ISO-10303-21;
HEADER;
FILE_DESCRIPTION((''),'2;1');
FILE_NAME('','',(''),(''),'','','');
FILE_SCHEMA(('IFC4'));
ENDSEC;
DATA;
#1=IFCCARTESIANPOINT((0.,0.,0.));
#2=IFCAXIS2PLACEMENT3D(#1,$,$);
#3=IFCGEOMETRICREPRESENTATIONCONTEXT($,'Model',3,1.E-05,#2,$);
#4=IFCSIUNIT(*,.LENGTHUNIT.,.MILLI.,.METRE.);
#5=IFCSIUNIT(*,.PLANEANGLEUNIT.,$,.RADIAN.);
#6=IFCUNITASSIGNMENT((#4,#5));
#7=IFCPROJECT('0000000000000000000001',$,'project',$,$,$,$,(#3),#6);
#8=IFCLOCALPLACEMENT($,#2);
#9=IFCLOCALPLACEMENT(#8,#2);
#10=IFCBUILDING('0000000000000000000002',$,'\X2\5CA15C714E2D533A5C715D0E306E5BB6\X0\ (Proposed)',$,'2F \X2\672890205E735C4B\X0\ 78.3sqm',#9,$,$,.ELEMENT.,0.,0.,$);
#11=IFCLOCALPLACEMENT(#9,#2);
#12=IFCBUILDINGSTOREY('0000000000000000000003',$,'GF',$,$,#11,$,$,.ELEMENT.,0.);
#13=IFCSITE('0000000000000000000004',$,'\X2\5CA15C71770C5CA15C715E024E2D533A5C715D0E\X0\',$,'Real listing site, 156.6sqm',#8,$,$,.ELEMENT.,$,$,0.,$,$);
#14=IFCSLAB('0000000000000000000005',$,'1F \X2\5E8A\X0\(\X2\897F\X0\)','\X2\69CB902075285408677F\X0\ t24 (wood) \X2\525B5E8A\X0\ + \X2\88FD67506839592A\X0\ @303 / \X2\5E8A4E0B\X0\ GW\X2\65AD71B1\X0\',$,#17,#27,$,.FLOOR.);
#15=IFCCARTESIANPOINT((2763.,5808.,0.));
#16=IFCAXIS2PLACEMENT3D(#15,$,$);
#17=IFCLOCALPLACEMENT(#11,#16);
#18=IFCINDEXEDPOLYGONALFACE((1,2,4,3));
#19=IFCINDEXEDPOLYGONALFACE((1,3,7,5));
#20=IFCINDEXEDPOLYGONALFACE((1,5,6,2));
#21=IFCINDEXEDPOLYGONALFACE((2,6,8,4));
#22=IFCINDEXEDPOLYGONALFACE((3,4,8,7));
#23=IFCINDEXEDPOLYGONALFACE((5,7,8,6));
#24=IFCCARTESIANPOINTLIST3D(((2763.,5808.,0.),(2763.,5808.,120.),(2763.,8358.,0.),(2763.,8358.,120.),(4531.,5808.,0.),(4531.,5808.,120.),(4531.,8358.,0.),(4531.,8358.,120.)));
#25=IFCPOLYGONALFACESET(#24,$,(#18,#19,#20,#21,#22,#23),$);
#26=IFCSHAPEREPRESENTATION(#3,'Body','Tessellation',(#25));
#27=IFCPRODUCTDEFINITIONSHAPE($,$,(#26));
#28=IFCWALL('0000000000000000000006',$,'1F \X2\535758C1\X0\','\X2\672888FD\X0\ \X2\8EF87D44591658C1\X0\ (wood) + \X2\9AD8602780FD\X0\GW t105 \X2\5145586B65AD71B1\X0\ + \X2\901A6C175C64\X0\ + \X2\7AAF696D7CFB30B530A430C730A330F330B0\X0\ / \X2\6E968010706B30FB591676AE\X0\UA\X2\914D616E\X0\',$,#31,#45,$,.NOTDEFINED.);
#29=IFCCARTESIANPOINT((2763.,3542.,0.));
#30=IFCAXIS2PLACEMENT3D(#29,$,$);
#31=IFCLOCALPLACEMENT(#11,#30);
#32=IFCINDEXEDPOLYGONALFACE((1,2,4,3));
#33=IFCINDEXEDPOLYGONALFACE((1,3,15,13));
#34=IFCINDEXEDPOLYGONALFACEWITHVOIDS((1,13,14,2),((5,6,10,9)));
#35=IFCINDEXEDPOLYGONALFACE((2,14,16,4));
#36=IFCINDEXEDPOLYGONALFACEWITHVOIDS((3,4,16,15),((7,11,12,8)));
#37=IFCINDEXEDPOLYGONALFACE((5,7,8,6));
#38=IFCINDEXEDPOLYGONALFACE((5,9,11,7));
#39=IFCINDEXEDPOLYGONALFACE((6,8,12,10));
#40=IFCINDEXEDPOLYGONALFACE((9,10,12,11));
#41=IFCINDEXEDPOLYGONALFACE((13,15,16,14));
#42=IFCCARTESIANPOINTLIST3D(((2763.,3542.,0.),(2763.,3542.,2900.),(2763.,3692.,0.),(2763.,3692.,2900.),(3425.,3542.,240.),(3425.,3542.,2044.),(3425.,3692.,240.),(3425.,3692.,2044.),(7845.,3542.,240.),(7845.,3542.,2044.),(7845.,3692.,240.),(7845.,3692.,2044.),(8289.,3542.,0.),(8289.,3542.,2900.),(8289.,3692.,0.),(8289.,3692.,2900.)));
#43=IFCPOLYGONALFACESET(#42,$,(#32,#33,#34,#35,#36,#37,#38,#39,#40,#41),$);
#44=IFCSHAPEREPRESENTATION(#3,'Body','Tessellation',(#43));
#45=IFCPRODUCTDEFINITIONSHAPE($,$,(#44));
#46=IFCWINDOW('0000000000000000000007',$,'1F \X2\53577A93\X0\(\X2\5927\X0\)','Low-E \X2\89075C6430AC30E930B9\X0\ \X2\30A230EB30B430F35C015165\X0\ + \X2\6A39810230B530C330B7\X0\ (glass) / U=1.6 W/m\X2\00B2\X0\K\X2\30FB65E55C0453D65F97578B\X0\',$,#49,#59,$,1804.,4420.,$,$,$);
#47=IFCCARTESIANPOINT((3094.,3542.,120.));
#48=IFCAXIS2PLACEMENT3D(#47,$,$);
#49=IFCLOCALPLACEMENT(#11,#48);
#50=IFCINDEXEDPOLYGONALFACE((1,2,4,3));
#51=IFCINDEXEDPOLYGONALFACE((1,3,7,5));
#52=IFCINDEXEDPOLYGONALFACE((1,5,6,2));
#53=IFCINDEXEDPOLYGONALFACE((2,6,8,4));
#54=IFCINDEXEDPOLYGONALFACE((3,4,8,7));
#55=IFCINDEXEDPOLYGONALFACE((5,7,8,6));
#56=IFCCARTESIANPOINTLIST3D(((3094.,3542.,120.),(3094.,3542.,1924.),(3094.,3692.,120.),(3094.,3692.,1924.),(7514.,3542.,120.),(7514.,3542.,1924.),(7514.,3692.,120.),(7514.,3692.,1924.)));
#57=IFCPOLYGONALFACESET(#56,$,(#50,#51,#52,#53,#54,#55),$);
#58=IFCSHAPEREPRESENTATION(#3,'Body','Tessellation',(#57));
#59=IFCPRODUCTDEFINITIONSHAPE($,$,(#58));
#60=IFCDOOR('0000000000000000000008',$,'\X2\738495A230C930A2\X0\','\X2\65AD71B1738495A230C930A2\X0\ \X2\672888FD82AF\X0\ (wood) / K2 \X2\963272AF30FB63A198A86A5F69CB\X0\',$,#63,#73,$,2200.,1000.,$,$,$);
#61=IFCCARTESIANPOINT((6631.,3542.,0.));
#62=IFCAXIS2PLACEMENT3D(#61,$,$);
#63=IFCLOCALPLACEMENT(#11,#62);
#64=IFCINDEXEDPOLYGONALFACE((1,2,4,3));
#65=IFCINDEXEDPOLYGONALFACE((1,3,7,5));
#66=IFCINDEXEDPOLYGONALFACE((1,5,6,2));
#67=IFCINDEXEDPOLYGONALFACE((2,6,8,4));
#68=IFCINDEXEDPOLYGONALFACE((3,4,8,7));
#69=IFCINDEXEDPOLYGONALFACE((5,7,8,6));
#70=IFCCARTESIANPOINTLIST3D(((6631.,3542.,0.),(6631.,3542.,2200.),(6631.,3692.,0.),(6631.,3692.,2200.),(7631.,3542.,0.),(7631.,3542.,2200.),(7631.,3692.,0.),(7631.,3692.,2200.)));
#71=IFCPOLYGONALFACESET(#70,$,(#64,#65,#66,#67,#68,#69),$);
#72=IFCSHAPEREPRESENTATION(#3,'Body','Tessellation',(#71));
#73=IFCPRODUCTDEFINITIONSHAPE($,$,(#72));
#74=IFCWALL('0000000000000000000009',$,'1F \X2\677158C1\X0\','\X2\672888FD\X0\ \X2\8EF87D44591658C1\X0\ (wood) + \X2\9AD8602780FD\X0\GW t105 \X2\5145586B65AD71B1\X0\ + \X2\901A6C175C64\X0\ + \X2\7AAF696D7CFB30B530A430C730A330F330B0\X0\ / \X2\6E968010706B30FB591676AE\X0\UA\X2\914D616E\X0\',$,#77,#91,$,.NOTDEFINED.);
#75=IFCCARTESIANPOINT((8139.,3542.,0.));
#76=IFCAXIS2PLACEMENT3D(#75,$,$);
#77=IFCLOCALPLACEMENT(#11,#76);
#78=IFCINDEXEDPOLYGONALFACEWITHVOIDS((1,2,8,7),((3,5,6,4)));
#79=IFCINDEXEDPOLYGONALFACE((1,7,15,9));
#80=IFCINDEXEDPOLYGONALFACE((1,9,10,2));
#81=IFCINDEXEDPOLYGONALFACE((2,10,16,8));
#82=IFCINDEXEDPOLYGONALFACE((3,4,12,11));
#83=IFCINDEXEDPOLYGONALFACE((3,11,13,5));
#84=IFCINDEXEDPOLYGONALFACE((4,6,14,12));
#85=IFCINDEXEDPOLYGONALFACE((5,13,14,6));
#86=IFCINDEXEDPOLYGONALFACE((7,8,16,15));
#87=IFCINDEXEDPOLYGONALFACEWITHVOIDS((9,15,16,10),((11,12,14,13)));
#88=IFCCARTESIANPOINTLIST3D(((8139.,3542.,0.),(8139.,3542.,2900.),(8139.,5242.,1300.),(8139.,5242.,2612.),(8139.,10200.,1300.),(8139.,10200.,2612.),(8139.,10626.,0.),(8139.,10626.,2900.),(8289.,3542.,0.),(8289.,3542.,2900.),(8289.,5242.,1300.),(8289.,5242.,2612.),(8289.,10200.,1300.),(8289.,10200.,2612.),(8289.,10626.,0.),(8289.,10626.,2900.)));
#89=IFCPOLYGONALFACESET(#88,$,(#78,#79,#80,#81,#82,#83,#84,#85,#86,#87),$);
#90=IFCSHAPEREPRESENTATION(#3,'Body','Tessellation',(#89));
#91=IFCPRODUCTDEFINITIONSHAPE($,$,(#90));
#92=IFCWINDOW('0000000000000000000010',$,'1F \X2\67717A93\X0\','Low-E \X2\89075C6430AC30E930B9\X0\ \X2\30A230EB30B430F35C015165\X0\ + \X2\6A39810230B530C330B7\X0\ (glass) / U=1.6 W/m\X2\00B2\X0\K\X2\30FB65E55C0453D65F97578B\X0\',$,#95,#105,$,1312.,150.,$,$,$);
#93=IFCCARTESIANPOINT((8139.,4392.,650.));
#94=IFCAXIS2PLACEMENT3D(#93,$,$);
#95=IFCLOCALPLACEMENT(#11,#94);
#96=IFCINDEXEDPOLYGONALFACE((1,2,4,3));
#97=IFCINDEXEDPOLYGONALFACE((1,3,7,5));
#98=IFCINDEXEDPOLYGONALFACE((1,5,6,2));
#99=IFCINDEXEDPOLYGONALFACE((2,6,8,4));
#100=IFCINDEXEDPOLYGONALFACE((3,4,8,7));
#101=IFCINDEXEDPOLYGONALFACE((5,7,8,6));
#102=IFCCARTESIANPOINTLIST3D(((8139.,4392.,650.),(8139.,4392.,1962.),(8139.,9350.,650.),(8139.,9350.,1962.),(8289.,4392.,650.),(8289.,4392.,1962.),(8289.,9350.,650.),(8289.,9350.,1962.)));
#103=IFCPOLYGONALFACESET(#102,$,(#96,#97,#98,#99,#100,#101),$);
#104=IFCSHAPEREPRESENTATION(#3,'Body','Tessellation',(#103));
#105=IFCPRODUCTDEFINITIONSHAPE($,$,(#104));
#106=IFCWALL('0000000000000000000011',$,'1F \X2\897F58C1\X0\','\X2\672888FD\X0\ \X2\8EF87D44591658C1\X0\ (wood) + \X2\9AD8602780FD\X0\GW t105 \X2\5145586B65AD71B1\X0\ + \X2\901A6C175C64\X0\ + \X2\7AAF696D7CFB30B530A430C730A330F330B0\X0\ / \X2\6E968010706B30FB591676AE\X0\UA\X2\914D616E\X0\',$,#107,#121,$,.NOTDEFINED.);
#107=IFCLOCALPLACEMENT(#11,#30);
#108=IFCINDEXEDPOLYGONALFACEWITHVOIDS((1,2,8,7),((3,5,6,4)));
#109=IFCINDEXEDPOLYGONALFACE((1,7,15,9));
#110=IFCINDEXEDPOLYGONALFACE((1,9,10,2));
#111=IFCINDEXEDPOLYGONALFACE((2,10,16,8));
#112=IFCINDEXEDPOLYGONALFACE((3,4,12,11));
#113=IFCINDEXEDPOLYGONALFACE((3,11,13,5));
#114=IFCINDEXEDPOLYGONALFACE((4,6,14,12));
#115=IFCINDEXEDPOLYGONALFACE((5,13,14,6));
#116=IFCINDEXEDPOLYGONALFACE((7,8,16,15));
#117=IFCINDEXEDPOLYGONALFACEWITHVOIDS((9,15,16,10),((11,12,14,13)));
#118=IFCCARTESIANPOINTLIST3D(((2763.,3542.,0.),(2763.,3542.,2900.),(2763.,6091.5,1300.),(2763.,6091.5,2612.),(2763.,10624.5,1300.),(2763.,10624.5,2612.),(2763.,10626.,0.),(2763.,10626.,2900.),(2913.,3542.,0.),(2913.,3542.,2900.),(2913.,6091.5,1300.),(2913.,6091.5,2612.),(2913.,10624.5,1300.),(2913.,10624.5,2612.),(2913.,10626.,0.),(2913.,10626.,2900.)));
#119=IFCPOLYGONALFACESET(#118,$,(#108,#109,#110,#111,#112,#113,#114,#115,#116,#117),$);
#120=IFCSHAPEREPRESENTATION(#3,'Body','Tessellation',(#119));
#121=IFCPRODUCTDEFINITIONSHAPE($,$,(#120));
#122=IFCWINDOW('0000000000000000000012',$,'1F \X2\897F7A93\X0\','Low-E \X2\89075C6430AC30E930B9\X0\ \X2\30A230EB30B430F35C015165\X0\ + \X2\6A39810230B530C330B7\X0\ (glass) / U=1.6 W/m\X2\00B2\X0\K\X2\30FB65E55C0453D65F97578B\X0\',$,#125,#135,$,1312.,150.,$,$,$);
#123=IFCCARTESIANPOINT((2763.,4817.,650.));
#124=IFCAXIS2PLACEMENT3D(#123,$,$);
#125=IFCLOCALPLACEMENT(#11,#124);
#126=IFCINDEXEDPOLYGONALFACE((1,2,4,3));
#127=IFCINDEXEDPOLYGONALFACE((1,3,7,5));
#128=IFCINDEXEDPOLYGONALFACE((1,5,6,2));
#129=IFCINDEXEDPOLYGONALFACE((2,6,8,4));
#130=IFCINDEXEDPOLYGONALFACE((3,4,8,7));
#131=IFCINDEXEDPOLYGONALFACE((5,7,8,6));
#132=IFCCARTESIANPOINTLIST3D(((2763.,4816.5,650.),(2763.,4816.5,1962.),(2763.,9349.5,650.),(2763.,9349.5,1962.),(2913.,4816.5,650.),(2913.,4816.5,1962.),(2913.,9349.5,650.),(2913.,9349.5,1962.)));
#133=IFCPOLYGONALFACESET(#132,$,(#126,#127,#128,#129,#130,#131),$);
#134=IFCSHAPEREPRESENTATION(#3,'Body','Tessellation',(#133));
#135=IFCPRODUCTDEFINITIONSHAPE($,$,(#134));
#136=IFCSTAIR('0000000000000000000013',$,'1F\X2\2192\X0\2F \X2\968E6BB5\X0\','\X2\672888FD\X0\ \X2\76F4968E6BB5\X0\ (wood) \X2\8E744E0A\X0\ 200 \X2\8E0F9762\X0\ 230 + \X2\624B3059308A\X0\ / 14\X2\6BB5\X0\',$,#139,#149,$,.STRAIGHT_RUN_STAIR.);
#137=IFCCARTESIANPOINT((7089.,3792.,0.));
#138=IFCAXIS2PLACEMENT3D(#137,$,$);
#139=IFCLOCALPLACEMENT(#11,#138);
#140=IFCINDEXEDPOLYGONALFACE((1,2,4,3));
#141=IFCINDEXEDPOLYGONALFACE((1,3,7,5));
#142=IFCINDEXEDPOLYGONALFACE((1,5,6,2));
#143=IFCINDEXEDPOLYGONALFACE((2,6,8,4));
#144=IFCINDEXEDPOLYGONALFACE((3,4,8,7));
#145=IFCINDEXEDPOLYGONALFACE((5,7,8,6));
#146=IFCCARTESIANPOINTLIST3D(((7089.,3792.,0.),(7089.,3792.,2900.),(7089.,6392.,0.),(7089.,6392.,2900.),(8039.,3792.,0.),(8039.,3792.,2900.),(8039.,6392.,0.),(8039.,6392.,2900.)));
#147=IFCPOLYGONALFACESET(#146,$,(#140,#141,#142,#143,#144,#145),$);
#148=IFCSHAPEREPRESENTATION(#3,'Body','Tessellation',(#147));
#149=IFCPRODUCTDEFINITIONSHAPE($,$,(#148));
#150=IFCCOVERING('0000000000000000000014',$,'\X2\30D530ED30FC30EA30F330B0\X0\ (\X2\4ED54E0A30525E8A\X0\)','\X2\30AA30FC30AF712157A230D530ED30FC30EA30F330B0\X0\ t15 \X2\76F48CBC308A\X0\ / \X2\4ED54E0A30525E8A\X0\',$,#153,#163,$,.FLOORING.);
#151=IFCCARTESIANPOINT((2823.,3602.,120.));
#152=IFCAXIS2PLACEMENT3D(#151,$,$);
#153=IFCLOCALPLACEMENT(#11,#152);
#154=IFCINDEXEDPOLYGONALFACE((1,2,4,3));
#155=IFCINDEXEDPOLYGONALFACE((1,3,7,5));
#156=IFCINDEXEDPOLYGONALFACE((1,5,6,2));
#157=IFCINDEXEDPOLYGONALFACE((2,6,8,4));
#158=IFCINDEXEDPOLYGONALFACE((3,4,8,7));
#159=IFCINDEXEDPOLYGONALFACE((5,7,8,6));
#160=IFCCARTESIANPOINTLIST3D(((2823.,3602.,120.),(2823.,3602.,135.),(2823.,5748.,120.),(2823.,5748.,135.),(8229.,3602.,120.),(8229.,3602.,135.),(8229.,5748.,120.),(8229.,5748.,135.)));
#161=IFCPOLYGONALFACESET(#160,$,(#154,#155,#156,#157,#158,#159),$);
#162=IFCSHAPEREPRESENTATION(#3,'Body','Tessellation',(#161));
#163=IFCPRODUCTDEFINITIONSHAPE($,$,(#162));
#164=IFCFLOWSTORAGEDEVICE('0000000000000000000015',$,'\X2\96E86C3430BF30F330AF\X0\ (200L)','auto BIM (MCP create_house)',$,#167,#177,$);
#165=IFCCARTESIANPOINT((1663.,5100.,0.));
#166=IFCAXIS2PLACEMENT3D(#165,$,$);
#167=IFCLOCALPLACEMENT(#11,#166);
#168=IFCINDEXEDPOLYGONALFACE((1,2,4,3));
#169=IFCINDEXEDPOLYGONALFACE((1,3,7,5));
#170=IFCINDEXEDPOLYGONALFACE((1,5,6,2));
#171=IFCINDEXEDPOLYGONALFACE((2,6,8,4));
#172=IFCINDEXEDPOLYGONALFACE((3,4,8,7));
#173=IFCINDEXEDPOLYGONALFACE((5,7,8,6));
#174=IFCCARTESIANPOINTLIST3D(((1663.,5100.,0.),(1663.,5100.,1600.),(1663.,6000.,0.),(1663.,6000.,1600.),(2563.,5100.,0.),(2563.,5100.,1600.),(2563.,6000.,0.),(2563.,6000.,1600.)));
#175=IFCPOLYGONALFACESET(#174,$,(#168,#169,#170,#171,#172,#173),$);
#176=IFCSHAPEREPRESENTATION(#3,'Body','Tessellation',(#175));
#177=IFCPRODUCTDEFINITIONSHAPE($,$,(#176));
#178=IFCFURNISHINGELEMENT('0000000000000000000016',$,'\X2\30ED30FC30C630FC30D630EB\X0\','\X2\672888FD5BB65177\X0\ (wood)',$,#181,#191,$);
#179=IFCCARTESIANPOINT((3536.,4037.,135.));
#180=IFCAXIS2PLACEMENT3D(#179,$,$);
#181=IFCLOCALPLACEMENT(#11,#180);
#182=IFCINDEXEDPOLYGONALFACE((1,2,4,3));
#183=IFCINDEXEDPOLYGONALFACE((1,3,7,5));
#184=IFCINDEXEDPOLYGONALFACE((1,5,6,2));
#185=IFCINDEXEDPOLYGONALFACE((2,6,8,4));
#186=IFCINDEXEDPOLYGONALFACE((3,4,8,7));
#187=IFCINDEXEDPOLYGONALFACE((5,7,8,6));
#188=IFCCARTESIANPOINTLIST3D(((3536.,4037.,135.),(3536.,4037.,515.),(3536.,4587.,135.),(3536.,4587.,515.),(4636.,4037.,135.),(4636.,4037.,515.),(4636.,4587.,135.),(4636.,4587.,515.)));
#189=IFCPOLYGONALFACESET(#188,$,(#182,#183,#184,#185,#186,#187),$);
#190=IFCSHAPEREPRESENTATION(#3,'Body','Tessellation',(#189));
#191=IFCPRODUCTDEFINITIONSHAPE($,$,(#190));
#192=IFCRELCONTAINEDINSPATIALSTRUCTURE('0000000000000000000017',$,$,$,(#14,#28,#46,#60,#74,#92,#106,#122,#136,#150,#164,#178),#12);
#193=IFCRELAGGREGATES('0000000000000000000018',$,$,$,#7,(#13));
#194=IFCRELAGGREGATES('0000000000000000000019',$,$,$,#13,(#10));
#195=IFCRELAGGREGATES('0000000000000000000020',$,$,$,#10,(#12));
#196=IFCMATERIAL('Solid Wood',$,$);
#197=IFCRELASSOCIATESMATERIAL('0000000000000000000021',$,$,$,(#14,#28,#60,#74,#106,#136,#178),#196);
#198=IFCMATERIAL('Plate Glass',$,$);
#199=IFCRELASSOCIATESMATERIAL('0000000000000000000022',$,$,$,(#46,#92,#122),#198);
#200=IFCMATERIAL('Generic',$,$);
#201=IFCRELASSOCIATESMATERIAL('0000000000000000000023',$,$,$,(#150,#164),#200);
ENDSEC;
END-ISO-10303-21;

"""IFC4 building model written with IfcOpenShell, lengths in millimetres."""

from ifc_helpers import new_model, si_unit, frame, frame_2d, origin, place, context, project, spatial, rectangle, extrude, material, element, fill, save


model = new_model("IFC4")

# Units and contexts
model_context = context("Model", 3, precision=1e-05, world=origin())
ifc_project = project(units=[si_unit("LENGTHUNIT", "METRE", prefix="MILLI"), si_unit("PLANEANGLEUNIT", "RADIAN")], contexts=[model_context])

# Site, building, storey
site_placement = place(None, origin())
site = spatial("IfcSite", under=ifc_project, at=site_placement, Name="岡山県岡山市中区山崎", ObjectType="Real listing site, 156.6sqm", CompositionType="ELEMENT", RefElevation=0.0)
building_placement = place(site_placement, origin())
building = spatial("IfcBuilding", under=site, at=building_placement, Name="岡山中区山崎の家 (Proposed)", ObjectType="2F 木造平屋 78.3sqm", CompositionType="ELEMENT", ElevationOfRefHeight=0.0, ElevationOfTerrain=0.0)
storey_placement = place(building_placement, origin())
storey = spatial("IfcBuildingStorey", under=building, at=storey_placement, Name="GF", CompositionType="ELEMENT", Elevation=0.0)

# Slab
ifc_material_1 = material(Name="Solid Wood")
slab_1_placement = place(storey_placement, frame((2763.0, 5808.0, 0.0)))
element("IfcSlab", 1, at=slab_1_placement, inside=storey, material=ifc_material_1, Name="1F 床(西)", Description="構造用合板 t24 (wood) 剛床 + 製材根太 @303 / 床下 GW断熱", PredefinedType="FLOOR", context=model_context, shape_type="SweptSolid", body=[
    extrude(rectangle(XDim=1768.0, YDim=2550.0, at=frame_2d((884.0, 1275.0))), frame((2763.0, 5808.0, 0.0)), (0.0, 0.0, 1.0), 120.0),
])

# Wall, openings, window, door
wall_1_placement = place(storey_placement, frame((2763.0, 3542.0, 0.0)))
wall_1 = element("IfcWall", 2, at=wall_1_placement, inside=storey, material=ifc_material_1, Name="1F 南壁", Description="木製 軸組外壁 (wood) + 高性能GW t105 充填断熱 + 通気層 + 窯業系サイディング / 準耐火・外皮UA配慮", PredefinedType="NOTDEFINED", context=model_context, shape_type="SweptSolid", body=[
    extrude(rectangle(XDim=5526.0, YDim=150.0, at=frame_2d((2763.0, 75.0))), frame((2763.0, 3542.0, 0.0)), (0.0, 0.0, 1.0), 2900.0),
])
opening_1_placement = place(storey_placement, frame((3094.0, 3542.0, 120.0)))
opening_1 = element("IfcOpeningElement", 3, at=opening_1_placement, cuts=wall_1, PredefinedType="NOTDEFINED", context=model_context, shape_type="SweptSolid", body=[
    extrude(rectangle(XDim=4420.0, YDim=150.0, at=frame_2d((2210.0, 75.0))), frame((3094.0, 3542.0, 120.0)), (0.0, 0.0, 1.0), 1804.0),
])
opening_2_placement = place(storey_placement, frame((6631.0, 3542.0, 0.0)))
opening_2 = element("IfcOpeningElement", 4, at=opening_2_placement, cuts=wall_1, PredefinedType="NOTDEFINED", context=model_context, shape_type="SweptSolid", body=[
    extrude(rectangle(XDim=1000.0, YDim=150.0, at=frame_2d((500.0, 75.0))), frame((6631.0, 3542.0, 0.0)), (0.0, 0.0, 1.0), 2200.0),
])
ifc_material_2 = material(Name="Plate Glass")
window_1_placement = place(storey_placement, frame((3094.0, 3542.0, 120.0)))
window_1 = element("IfcWindow", 5, at=window_1_placement, inside=storey, material=ifc_material_2, Name="1F 南窓(大)", Description="Low-E 複層ガラス アルゴン封入 + 樹脂サッシ (glass) / U=1.6 W/m²K・日射取得型", OverallHeight=1804.0, OverallWidth=4420.0, context=model_context, shape_type="SweptSolid", body=[
    extrude(rectangle(XDim=4420.0, YDim=150.0, at=frame_2d((2210.0, 75.0))), frame((3094.0, 3542.0, 120.0)), (0.0, 0.0, 1.0), 1804.0),
])
fill(opening_1, window_1)
door_placement = place(storey_placement, frame((6631.0, 3542.0, 0.0)))
door = element("IfcDoor", 6, at=door_placement, inside=storey, material=ifc_material_1, Name="玄関ドア", Description="断熱玄関ドア 木製芯 (wood) / K2 防犯・採風機構", OverallHeight=2200.0, OverallWidth=1000.0, context=model_context, shape_type="SweptSolid", body=[
    extrude(rectangle(XDim=1000.0, YDim=150.0, at=frame_2d((500.0, 75.0))), frame((6631.0, 3542.0, 0.0)), (0.0, 0.0, 1.0), 2200.0),
])
fill(opening_2, door)

# Walls, openings, windows
wall_2_placement = place(storey_placement, frame((8139.0, 3542.0, 0.0)))
wall_2 = element("IfcWall", 7, at=wall_2_placement, inside=storey, material=ifc_material_1, Name="1F 東壁", Description="木製 軸組外壁 (wood) + 高性能GW t105 充填断熱 + 通気層 + 窯業系サイディング / 準耐火・外皮UA配慮", PredefinedType="NOTDEFINED", context=model_context, shape_type="SweptSolid", body=[
    extrude(rectangle(XDim=150.0, YDim=7084.0, at=frame_2d((75.0, 3542.0))), frame((8139.0, 3542.0, 0.0)), (0.0, 0.0, 1.0), 2900.0),
])
opening_3_placement = place(storey_placement, frame((8139.0, 4392.0, 650.0)))
opening_3 = element("IfcOpeningElement", 8, at=opening_3_placement, cuts=wall_2, PredefinedType="NOTDEFINED", context=model_context, shape_type="SweptSolid", body=[
    extrude(rectangle(XDim=150.0, YDim=4958.0, at=frame_2d((75.0, 2479.0))), frame((8139.0, 4392.0, 650.0)), (0.0, 0.0, 1.0), 1312.0),
])
window_2_placement = place(storey_placement, frame((8139.0, 4392.0, 650.0)))
window_2 = element("IfcWindow", 9, at=window_2_placement, inside=storey, material=ifc_material_2, Name="1F 東窓", Description="Low-E 複層ガラス アルゴン封入 + 樹脂サッシ (glass) / U=1.6 W/m²K・日射取得型", OverallHeight=1312.0, OverallWidth=150.0, context=model_context, shape_type="SweptSolid", body=[
    extrude(rectangle(XDim=150.0, YDim=4958.0, at=frame_2d((75.0, 2479.0))), frame((8139.0, 4392.0, 650.0)), (0.0, 0.0, 1.0), 1312.0),
])
fill(opening_3, window_2)
wall_3_placement = place(storey_placement, frame((2763.0, 3542.0, 0.0)))
wall_3 = element("IfcWall", 10, at=wall_3_placement, inside=storey, material=ifc_material_1, Name="1F 西壁", Description="木製 軸組外壁 (wood) + 高性能GW t105 充填断熱 + 通気層 + 窯業系サイディング / 準耐火・外皮UA配慮", PredefinedType="NOTDEFINED", context=model_context, shape_type="SweptSolid", body=[
    extrude(rectangle(XDim=150.0, YDim=7084.0, at=frame_2d((75.0, 3542.0))), frame((2763.0, 3542.0, 0.0)), (0.0, 0.0, 1.0), 2900.0),
])
opening_4_placement = place(storey_placement, frame((2763.0, 4817.0, 650.0)))
opening_4 = element("IfcOpeningElement", 11, at=opening_4_placement, cuts=wall_3, PredefinedType="NOTDEFINED", context=model_context, shape_type="SweptSolid", body=[
    extrude(rectangle(XDim=150.0, YDim=4533.0, at=frame_2d((75.0, 2266.0))), frame((2763.0, 4817.0, 650.0)), (0.0, 0.0, 1.0), 1312.0),
])
window_3_placement = place(storey_placement, frame((2763.0, 4817.0, 650.0)))
window_3 = element("IfcWindow", 12, at=window_3_placement, inside=storey, material=ifc_material_2, Name="1F 西窓", Description="Low-E 複層ガラス アルゴン封入 + 樹脂サッシ (glass) / U=1.6 W/m²K・日射取得型", OverallHeight=1312.0, OverallWidth=150.0, context=model_context, shape_type="SweptSolid", body=[
    extrude(rectangle(XDim=150.0, YDim=4533.0, at=frame_2d((75.0, 2266.0))), frame((2763.0, 4817.0, 650.0)), (0.0, 0.0, 1.0), 1312.0),
])
fill(opening_4, window_3)

# Stair
stair_placement = place(storey_placement, frame((7089.0, 3792.0, 0.0)))
element("IfcStair", 13, at=stair_placement, inside=storey, material=ifc_material_1, Name="1F→2F 階段", Description="木製 直階段 (wood) 蹴上 200 踏面 230 + 手すり / 14段", PredefinedType="STRAIGHT_RUN_STAIR", context=model_context, shape_type="SweptSolid", body=[
    extrude(rectangle(XDim=950.0, YDim=2600.0, at=frame_2d((475.0, 1300.0))), frame((7089.0, 3792.0, 0.0)), (0.0, 0.0, 1.0), 2900.0),
])

# Covering
ifc_material_3 = material(Name="Generic")
covering_placement = place(storey_placement, frame((2823.0, 3602.0, 120.0)))
element("IfcCovering", 14, at=covering_placement, inside=storey, material=ifc_material_3, Name="フローリング (仕上げ床)", Description="オーク無垢フローリング t15 直貼り / 仕上げ床", PredefinedType="FLOORING", context=model_context, shape_type="SweptSolid", body=[
    extrude(rectangle(XDim=5406.0, YDim=2146.0, at=frame_2d((2703.0, 1073.0))), frame((2823.0, 3602.0, 120.0)), (0.0, 0.0, 1.0), 15.0),
])

# Flow storage device
flow_storage_device_placement = place(storey_placement, frame((1663.0, 5100.0, 0.0)))
element("IfcFlowStorageDevice", 15, at=flow_storage_device_placement, inside=storey, material=ifc_material_3, Name="雨水タンク (200L)", Description="auto BIM (MCP create_house)", context=model_context, shape_type="SweptSolid", body=[
    extrude(rectangle(XDim=900.0, YDim=900.0, at=frame_2d((450.0, 450.0))), frame((1663.0, 5100.0, 0.0)), (0.0, 0.0, 1.0), 1600.0),
])

# Furnishing element
furnishing_1_placement = place(storey_placement, frame((3536.0, 4037.0, 135.0)))
element("IfcFurnishingElement", 16, at=furnishing_1_placement, inside=storey, material=ifc_material_1, Name="ローテーブル", Description="木製家具 (wood)", context=model_context, shape_type="SweptSolid", body=[
    extrude(rectangle(XDim=1100.0, YDim=550.0, at=frame_2d((550.0, 275.0))), frame((3536.0, 4037.0, 135.0)), (0.0, 0.0, 1.0), 380.0),
])

save(model, "model.ifc")
